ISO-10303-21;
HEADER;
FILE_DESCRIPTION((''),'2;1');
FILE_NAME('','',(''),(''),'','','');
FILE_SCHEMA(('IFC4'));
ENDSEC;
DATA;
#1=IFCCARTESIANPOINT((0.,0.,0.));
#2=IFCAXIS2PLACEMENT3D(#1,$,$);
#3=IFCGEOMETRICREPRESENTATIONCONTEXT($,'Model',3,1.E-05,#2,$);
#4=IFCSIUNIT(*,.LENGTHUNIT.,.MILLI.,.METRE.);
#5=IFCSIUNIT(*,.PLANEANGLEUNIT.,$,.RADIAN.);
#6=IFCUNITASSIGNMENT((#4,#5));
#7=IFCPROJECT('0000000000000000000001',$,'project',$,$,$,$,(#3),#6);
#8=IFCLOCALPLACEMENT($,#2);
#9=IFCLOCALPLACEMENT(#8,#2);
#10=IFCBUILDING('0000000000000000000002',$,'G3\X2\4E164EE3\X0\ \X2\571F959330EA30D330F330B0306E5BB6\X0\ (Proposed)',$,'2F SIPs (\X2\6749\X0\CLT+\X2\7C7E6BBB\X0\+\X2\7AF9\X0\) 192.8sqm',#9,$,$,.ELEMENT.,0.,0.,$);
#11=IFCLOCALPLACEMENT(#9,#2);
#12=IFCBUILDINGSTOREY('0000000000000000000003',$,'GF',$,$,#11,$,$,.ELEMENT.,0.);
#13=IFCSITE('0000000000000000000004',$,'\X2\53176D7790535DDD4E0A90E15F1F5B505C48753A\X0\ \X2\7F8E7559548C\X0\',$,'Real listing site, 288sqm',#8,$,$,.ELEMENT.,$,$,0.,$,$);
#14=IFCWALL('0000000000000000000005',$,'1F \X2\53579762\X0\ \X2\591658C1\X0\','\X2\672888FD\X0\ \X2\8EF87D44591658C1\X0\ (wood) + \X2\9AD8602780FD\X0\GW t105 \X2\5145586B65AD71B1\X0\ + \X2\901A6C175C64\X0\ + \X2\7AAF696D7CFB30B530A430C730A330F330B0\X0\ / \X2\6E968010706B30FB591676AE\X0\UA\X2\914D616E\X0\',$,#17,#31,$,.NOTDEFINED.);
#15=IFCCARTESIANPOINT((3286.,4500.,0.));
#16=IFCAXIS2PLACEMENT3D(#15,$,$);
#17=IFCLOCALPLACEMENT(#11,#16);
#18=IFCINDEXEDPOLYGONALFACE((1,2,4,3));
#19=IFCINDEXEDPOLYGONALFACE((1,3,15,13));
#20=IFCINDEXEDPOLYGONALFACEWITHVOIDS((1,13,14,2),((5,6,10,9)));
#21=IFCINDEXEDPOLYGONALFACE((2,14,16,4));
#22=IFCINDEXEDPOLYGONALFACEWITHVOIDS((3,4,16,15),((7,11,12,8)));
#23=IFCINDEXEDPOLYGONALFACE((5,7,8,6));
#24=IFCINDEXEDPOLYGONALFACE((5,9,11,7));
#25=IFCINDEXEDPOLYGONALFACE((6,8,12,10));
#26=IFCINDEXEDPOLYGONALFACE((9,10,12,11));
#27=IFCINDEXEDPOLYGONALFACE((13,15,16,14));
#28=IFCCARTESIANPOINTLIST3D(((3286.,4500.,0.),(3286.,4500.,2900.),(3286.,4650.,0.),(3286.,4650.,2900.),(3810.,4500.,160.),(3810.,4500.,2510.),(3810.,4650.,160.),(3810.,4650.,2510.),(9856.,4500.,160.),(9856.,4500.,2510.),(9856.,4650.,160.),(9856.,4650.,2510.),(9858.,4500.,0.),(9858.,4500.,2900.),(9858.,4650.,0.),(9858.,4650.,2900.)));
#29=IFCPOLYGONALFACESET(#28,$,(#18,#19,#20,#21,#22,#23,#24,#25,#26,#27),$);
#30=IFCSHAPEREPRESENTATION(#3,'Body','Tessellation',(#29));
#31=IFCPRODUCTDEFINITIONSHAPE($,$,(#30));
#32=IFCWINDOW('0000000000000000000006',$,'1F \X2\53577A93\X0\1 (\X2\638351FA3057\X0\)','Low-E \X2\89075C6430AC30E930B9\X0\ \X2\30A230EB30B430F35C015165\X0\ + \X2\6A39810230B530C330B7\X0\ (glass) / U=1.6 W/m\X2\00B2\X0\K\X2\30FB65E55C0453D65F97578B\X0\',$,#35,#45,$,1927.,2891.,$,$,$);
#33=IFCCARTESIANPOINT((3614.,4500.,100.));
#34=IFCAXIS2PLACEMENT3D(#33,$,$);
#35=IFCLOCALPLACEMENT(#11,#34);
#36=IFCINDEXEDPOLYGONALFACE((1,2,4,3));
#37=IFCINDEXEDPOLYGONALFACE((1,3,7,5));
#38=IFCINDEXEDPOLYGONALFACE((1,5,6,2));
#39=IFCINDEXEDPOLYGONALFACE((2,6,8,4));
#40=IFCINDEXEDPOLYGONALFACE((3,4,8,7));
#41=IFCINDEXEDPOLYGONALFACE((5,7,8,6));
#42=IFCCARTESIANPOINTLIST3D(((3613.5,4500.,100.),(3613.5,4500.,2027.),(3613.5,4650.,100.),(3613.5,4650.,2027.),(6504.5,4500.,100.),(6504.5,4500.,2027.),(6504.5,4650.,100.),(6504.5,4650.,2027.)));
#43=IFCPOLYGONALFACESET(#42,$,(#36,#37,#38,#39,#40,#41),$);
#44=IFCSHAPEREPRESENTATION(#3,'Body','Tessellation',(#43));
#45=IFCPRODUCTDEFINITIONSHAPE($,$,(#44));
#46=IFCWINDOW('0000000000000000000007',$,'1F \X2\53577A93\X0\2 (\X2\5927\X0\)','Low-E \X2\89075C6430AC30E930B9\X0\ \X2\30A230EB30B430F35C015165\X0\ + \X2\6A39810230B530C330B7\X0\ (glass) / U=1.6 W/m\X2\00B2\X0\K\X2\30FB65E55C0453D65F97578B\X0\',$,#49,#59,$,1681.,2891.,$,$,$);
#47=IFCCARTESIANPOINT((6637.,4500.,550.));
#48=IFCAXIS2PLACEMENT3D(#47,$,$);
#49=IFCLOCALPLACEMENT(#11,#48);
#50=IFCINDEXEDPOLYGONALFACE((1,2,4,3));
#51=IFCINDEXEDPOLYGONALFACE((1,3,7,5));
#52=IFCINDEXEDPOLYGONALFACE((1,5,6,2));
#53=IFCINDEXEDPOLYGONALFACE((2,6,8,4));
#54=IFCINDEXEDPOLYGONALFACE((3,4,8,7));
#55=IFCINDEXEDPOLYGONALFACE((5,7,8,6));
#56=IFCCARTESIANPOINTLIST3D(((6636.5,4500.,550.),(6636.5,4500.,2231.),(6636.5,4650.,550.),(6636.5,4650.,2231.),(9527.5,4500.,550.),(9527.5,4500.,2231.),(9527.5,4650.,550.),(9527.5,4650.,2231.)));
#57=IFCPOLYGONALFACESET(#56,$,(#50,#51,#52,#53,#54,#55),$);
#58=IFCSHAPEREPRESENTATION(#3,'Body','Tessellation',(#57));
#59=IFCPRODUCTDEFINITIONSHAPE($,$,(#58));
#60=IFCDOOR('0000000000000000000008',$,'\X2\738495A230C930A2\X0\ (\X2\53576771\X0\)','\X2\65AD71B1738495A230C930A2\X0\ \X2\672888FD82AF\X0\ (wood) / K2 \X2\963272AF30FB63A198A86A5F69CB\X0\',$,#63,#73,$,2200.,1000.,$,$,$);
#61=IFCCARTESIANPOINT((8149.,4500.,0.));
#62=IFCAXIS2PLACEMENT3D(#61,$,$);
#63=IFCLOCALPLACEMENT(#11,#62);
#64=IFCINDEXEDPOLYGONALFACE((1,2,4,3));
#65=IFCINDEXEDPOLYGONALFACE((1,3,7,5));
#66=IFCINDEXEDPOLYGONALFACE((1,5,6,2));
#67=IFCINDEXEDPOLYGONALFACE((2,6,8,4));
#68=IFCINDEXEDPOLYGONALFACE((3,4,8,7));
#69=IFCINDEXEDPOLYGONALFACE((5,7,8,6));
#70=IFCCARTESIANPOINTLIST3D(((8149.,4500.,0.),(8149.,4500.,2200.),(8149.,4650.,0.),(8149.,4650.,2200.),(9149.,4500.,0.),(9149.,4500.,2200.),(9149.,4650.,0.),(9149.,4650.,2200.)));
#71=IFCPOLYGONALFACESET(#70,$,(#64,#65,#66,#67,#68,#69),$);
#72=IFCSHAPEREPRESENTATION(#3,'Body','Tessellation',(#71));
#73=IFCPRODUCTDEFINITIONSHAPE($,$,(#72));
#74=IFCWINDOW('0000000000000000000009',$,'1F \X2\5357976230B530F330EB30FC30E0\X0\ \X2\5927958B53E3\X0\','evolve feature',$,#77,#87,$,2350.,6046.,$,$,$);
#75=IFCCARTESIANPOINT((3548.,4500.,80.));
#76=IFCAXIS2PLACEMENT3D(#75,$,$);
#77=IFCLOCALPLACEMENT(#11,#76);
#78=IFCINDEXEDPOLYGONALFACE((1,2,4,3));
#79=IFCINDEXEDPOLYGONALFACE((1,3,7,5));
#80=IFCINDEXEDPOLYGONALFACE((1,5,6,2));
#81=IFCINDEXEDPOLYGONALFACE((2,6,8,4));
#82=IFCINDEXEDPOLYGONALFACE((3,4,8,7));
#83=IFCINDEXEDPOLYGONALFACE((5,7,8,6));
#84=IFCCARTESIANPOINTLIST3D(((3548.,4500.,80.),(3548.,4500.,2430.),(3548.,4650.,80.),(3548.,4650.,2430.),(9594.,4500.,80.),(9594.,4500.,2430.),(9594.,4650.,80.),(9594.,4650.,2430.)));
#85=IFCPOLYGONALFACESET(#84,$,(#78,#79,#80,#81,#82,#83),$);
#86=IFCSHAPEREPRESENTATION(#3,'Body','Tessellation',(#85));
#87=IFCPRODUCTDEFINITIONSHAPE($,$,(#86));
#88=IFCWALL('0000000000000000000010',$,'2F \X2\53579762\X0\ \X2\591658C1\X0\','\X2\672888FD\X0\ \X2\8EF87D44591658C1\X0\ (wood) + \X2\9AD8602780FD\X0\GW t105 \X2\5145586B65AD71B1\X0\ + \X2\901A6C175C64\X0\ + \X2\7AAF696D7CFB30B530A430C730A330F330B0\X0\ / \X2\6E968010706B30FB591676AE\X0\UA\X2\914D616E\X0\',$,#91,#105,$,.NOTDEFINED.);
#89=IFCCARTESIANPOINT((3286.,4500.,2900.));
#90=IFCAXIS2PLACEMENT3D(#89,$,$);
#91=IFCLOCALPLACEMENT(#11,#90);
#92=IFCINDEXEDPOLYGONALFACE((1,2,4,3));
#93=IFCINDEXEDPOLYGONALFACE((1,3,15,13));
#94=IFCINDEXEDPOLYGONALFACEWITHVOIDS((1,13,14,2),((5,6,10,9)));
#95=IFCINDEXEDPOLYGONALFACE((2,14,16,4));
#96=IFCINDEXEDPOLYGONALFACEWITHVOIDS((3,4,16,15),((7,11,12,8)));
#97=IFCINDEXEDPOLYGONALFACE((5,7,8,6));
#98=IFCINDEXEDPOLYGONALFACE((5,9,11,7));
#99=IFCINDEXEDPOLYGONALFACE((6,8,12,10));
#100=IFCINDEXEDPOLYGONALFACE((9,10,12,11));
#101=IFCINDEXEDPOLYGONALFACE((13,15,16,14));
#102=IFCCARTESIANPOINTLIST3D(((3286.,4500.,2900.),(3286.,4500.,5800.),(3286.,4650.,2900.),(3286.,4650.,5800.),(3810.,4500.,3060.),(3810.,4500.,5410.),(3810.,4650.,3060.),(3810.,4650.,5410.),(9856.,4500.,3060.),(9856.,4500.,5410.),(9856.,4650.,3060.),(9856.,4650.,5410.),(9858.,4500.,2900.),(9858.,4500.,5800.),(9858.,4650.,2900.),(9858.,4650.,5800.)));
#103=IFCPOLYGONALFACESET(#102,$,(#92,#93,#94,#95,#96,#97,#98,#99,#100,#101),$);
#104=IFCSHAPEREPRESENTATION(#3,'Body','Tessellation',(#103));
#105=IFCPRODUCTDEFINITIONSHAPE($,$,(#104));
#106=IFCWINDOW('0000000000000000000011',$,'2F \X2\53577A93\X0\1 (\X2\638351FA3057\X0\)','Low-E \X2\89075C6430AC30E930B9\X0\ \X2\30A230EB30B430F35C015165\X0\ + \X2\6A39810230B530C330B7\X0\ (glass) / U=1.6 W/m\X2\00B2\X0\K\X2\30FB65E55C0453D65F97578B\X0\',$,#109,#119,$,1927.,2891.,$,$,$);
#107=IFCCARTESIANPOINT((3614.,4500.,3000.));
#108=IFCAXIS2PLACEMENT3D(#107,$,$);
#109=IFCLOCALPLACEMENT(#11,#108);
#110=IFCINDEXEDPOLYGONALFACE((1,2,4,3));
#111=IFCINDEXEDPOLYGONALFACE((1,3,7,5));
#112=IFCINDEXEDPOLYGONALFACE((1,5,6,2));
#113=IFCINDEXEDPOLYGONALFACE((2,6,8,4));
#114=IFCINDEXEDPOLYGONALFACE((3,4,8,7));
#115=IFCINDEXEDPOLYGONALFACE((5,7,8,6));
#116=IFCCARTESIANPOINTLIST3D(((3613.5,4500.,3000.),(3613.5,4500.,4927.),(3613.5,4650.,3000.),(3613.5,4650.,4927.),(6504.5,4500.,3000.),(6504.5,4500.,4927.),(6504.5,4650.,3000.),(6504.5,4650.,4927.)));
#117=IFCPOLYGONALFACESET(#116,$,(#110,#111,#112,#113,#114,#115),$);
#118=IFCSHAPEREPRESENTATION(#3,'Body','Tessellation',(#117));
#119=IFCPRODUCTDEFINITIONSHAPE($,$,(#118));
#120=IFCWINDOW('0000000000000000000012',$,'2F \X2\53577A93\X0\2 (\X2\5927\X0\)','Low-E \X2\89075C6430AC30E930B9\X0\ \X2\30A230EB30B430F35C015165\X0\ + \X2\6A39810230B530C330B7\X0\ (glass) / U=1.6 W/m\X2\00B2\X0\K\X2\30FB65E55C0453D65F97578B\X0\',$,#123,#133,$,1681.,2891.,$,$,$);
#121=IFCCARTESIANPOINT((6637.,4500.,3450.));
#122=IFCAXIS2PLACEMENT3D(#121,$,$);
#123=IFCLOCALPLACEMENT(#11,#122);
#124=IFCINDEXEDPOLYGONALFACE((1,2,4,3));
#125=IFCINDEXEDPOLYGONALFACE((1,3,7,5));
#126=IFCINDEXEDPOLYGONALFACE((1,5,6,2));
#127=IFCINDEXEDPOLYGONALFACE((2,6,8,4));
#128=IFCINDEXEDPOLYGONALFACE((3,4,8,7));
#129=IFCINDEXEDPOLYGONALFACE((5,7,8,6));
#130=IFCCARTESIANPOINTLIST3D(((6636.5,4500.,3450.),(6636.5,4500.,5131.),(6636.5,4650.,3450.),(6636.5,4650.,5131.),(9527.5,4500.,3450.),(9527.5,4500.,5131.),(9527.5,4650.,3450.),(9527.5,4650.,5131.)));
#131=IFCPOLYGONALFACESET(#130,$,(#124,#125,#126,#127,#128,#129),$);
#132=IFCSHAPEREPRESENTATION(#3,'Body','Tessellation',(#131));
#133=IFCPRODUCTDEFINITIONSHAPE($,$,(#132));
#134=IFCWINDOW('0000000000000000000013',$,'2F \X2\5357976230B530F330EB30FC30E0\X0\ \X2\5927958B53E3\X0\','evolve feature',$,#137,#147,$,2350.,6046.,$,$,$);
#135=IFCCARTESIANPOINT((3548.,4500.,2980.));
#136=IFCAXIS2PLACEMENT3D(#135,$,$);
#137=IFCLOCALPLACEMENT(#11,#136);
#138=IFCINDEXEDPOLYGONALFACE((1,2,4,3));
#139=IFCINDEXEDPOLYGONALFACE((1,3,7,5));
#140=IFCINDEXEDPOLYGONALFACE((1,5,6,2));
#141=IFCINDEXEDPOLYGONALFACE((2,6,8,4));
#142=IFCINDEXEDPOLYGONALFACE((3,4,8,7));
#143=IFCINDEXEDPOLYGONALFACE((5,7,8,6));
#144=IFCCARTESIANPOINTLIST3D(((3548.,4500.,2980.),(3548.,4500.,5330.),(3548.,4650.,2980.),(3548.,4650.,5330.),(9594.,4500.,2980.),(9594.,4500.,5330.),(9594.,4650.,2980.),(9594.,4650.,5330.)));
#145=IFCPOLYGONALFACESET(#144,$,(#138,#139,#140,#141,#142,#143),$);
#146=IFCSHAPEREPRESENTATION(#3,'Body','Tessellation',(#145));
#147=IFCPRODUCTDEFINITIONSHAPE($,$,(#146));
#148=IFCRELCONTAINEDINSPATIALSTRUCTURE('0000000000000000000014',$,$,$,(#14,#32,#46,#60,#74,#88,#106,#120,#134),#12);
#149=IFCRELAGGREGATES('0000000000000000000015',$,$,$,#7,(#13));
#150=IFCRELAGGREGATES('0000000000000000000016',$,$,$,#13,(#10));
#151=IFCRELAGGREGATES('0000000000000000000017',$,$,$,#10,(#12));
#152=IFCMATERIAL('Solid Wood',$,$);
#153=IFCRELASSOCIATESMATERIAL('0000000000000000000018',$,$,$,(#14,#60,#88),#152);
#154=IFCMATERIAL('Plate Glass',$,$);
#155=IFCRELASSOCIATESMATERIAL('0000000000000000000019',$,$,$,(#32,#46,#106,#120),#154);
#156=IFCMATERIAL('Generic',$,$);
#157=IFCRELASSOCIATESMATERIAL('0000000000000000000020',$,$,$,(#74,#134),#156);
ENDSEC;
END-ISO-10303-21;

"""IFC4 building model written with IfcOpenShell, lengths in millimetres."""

from ifc_helpers import new_model, si_unit, frame, frame_2d, origin, place, context, project, spatial, rectangle, extrude, material, element, fill, save


model = new_model("IFC4")

# Units and contexts
model_context = context("Model", 3, precision=1e-05, world=origin())
ifc_project = project(units=[si_unit("LENGTHUNIT", "METRE", prefix="MILLI"), si_unit("PLANEANGLEUNIT", "RADIAN")], contexts=[model_context])

# Site, building, storey
site_placement = place(None, origin())
site = spatial("IfcSite", under=ifc_project, at=site_placement, Name="北海道川上郡弟子屈町 美留和", ObjectType="Real listing site, 288sqm", CompositionType="ELEMENT", RefElevation=0.0)
building_placement = place(site_placement, origin())
building = spatial("IfcBuilding", under=site, at=building_placement, Name="G3世代 土間リビングの家 (Proposed)", ObjectType="2F SIPs (杉CLT+籾殻+竹) 192.8sqm", CompositionType="ELEMENT", ElevationOfRefHeight=0.0, ElevationOfTerrain=0.0)
storey_placement = place(building_placement, origin())
storey = spatial("IfcBuildingStorey", under=building, at=storey_placement, Name="GF", CompositionType="ELEMENT", Elevation=0.0)

# Shared definitions
ifc_material_1 = material(Name="Solid Wood")

# Wall, openings, windows, door
wall_1_placement = place(storey_placement, frame((3286.0, 4500.0, 0.0)))
wall_1 = element("IfcWall", 1, at=wall_1_placement, inside=storey, material=ifc_material_1, Name="1F 南面 外壁", Description="木製 軸組外壁 (wood) + 高性能GW t105 充填断熱 + 通気層 + 窯業系サイディング / 準耐火・外皮UA配慮", PredefinedType="NOTDEFINED", context=model_context, shape_type="SweptSolid", body=[
    extrude(rectangle(XDim=6572.0, YDim=150.0, at=frame_2d((3286.0, 75.0))), frame((3286.0, 4500.0, 0.0)), (0.0, 0.0, 1.0), 2900.0),
])
opening_1_placement = place(storey_placement, frame((3614.0, 4500.0, 100.0)))
opening_1 = element("IfcOpeningElement", 2, at=opening_1_placement, cuts=wall_1, PredefinedType="NOTDEFINED", context=model_context, shape_type="SweptSolid", body=[
    extrude(rectangle(XDim=2891.0, YDim=150.0, at=frame_2d((1445.0, 75.0))), frame((3614.0, 4500.0, 100.0)), (0.0, 0.0, 1.0), 1927.0),
])
opening_2_placement = place(storey_placement, frame((6637.0, 4500.0, 550.0)))
opening_2 = element("IfcOpeningElement", 3, at=opening_2_placement, cuts=wall_1, PredefinedType="NOTDEFINED", context=model_context, shape_type="SweptSolid", body=[
    extrude(rectangle(XDim=2891.0, YDim=150.0, at=frame_2d((1445.0, 75.0))), frame((6637.0, 4500.0, 550.0)), (0.0, 0.0, 1.0), 1681.0),
])
opening_3_placement = place(storey_placement, frame((8149.0, 4500.0, 0.0)))
opening_3 = element("IfcOpeningElement", 4, at=opening_3_placement, cuts=wall_1, PredefinedType="NOTDEFINED", context=model_context, shape_type="SweptSolid", body=[
    extrude(rectangle(XDim=1000.0, YDim=150.0, at=frame_2d((500.0, 75.0))), frame((8149.0, 4500.0, 0.0)), (0.0, 0.0, 1.0), 2200.0),
])
opening_4_placement = place(storey_placement, frame((3548.0, 4500.0, 80.0)))
opening_4 = element("IfcOpeningElement", 5, at=opening_4_placement, cuts=wall_1, PredefinedType="NOTDEFINED", context=model_context, shape_type="SweptSolid", body=[
    extrude(rectangle(XDim=6046.0, YDim=150.0, at=frame_2d((3023.0, 75.0))), frame((3548.0, 4500.0, 80.0)), (0.0, 0.0, 1.0), 2350.0),
])
ifc_material_2 = material(Name="Plate Glass")
window_1_placement = place(storey_placement, frame((3614.0, 4500.0, 100.0)))
window_1 = element("IfcWindow", 6, at=window_1_placement, inside=storey, material=ifc_material_2, Name="1F 南窓1 (掃出し)", Description="Low-E 複層ガラス アルゴン封入 + 樹脂サッシ (glass) / U=1.6 W/m²K・日射取得型", OverallHeight=1927.0, OverallWidth=2891.0, context=model_context, shape_type="SweptSolid", body=[
    extrude(rectangle(XDim=2891.0, YDim=150.0, at=frame_2d((1445.0, 75.0))), frame((3614.0, 4500.0, 100.0)), (0.0, 0.0, 1.0), 1927.0),
])
fill(opening_1, window_1)
window_2_placement = place(storey_placement, frame((6637.0, 4500.0, 550.0)))
window_2 = element("IfcWindow", 7, at=window_2_placement, inside=storey, material=ifc_material_2, Name="1F 南窓2 (大)", Description="Low-E 複層ガラス アルゴン封入 + 樹脂サッシ (glass) / U=1.6 W/m²K・日射取得型", OverallHeight=1681.0, OverallWidth=2891.0, context=model_context, shape_type="SweptSolid", body=[
    extrude(rectangle(XDim=2891.0, YDim=150.0, at=frame_2d((1445.0, 75.0))), frame((6637.0, 4500.0, 550.0)), (0.0, 0.0, 1.0), 1681.0),
])
fill(opening_2, window_2)
door_placement = place(storey_placement, frame((8149.0, 4500.0, 0.0)))
door = element("IfcDoor", 8, at=door_placement, inside=storey, material=ifc_material_1, Name="玄関ドア (南東)", Description="断熱玄関ドア 木製芯 (wood) / K2 防犯・採風機構", OverallHeight=2200.0, OverallWidth=1000.0, context=model_context, shape_type="SweptSolid", body=[
    extrude(rectangle(XDim=1000.0, YDim=150.0, at=frame_2d((500.0, 75.0))), frame((8149.0, 4500.0, 0.0)), (0.0, 0.0, 1.0), 2200.0),
])
fill(opening_3, door)
ifc_material_3 = material(Name="Generic")
window_3_placement = place(storey_placement, frame((3548.0, 4500.0, 80.0)))
window_3 = element("IfcWindow", 9, at=window_3_placement, inside=storey, material=ifc_material_3, Name="1F 南面サンルーム 大開口", Description="evolve feature", OverallHeight=2350.0, OverallWidth=6046.0, context=model_context, shape_type="SweptSolid", body=[
    extrude(rectangle(XDim=6046.0, YDim=150.0, at=frame_2d((3023.0, 75.0))), frame((3548.0, 4500.0, 80.0)), (0.0, 0.0, 1.0), 2350.0),
])
fill(opening_4, window_3)

# Wall, openings, windows
wall_2_placement = place(storey_placement, frame((3286.0, 4500.0, 2900.0)))
wall_2 = element("IfcWall", 10, at=wall_2_placement, inside=storey, material=ifc_material_1, Name="2F 南面 外壁", Description="木製 軸組外壁 (wood) + 高性能GW t105 充填断熱 + 通気層 + 窯業系サイディング / 準耐火・外皮UA配慮", PredefinedType="NOTDEFINED", context=model_context, shape_type="SweptSolid", body=[
    extrude(rectangle(XDim=6572.0, YDim=150.0, at=frame_2d((3286.0, 75.0))), frame((3286.0, 4500.0, 2900.0)), (0.0, 0.0, 1.0), 2900.0),
])
opening_5_placement = place(storey_placement, frame((3614.0, 4500.0, 3000.0)))
opening_5 = element("IfcOpeningElement", 11, at=opening_5_placement, cuts=wall_2, PredefinedType="NOTDEFINED", context=model_context, shape_type="SweptSolid", body=[
    extrude(rectangle(XDim=2891.0, YDim=150.0, at=frame_2d((1445.0, 75.0))), frame((3614.0, 4500.0, 3000.0)), (0.0, 0.0, 1.0), 1927.0),
])
opening_6_placement = place(storey_placement, frame((6637.0, 4500.0, 3450.0)))
opening_6 = element("IfcOpeningElement", 12, at=opening_6_placement, cuts=wall_2, PredefinedType="NOTDEFINED", context=model_context, shape_type="SweptSolid", body=[
    extrude(rectangle(XDim=2891.0, YDim=150.0, at=frame_2d((1445.0, 75.0))), frame((6637.0, 4500.0, 3450.0)), (0.0, 0.0, 1.0), 1681.0),
])
opening_7_placement = place(storey_placement, frame((3548.0, 4500.0, 2980.0)))
opening_7 = element("IfcOpeningElement", 13, at=opening_7_placement, cuts=wall_2, PredefinedType="NOTDEFINED", context=model_context, shape_type="SweptSolid", body=[
    extrude(rectangle(XDim=6046.0, YDim=150.0, at=frame_2d((3023.0, 75.0))), frame((3548.0, 4500.0, 2980.0)), (0.0, 0.0, 1.0), 2350.0),
])
window_4_placement = place(storey_placement, frame((3614.0, 4500.0, 3000.0)))
window_4 = element("IfcWindow", 14, at=window_4_placement, inside=storey, material=ifc_material_2, Name="2F 南窓1 (掃出し)", Description="Low-E 複層ガラス アルゴン封入 + 樹脂サッシ (glass) / U=1.6 W/m²K・日射取得型", OverallHeight=1927.0, OverallWidth=2891.0, context=model_context, shape_type="SweptSolid", body=[
    extrude(rectangle(XDim=2891.0, YDim=150.0, at=frame_2d((1445.0, 75.0))), frame((3614.0, 4500.0, 3000.0)), (0.0, 0.0, 1.0), 1927.0),
])
fill(opening_5, window_4)
window_5_placement = place(storey_placement, frame((6637.0, 4500.0, 3450.0)))
window_5 = element("IfcWindow", 15, at=window_5_placement, inside=storey, material=ifc_material_2, Name="2F 南窓2 (大)", Description="Low-E 複層ガラス アルゴン封入 + 樹脂サッシ (glass) / U=1.6 W/m²K・日射取得型", OverallHeight=1681.0, OverallWidth=2891.0, context=model_context, shape_type="SweptSolid", body=[
    extrude(rectangle(XDim=2891.0, YDim=150.0, at=frame_2d((1445.0, 75.0))), frame((6637.0, 4500.0, 3450.0)), (0.0, 0.0, 1.0), 1681.0),
])
fill(opening_6, window_5)
window_6_placement = place(storey_placement, frame((3548.0, 4500.0, 2980.0)))
window_6 = element("IfcWindow", 16, at=window_6_placement, inside=storey, material=ifc_material_3, Name="2F 南面サンルーム 大開口", Description="evolve feature", OverallHeight=2350.0, OverallWidth=6046.0, context=model_context, shape_type="SweptSolid", body=[
    extrude(rectangle(XDim=6046.0, YDim=150.0, at=frame_2d((3023.0, 75.0))), frame((3548.0, 4500.0, 2980.0)), (0.0, 0.0, 1.0), 2350.0),
])
fill(opening_7, window_6)

save(model, "model.ifc")
